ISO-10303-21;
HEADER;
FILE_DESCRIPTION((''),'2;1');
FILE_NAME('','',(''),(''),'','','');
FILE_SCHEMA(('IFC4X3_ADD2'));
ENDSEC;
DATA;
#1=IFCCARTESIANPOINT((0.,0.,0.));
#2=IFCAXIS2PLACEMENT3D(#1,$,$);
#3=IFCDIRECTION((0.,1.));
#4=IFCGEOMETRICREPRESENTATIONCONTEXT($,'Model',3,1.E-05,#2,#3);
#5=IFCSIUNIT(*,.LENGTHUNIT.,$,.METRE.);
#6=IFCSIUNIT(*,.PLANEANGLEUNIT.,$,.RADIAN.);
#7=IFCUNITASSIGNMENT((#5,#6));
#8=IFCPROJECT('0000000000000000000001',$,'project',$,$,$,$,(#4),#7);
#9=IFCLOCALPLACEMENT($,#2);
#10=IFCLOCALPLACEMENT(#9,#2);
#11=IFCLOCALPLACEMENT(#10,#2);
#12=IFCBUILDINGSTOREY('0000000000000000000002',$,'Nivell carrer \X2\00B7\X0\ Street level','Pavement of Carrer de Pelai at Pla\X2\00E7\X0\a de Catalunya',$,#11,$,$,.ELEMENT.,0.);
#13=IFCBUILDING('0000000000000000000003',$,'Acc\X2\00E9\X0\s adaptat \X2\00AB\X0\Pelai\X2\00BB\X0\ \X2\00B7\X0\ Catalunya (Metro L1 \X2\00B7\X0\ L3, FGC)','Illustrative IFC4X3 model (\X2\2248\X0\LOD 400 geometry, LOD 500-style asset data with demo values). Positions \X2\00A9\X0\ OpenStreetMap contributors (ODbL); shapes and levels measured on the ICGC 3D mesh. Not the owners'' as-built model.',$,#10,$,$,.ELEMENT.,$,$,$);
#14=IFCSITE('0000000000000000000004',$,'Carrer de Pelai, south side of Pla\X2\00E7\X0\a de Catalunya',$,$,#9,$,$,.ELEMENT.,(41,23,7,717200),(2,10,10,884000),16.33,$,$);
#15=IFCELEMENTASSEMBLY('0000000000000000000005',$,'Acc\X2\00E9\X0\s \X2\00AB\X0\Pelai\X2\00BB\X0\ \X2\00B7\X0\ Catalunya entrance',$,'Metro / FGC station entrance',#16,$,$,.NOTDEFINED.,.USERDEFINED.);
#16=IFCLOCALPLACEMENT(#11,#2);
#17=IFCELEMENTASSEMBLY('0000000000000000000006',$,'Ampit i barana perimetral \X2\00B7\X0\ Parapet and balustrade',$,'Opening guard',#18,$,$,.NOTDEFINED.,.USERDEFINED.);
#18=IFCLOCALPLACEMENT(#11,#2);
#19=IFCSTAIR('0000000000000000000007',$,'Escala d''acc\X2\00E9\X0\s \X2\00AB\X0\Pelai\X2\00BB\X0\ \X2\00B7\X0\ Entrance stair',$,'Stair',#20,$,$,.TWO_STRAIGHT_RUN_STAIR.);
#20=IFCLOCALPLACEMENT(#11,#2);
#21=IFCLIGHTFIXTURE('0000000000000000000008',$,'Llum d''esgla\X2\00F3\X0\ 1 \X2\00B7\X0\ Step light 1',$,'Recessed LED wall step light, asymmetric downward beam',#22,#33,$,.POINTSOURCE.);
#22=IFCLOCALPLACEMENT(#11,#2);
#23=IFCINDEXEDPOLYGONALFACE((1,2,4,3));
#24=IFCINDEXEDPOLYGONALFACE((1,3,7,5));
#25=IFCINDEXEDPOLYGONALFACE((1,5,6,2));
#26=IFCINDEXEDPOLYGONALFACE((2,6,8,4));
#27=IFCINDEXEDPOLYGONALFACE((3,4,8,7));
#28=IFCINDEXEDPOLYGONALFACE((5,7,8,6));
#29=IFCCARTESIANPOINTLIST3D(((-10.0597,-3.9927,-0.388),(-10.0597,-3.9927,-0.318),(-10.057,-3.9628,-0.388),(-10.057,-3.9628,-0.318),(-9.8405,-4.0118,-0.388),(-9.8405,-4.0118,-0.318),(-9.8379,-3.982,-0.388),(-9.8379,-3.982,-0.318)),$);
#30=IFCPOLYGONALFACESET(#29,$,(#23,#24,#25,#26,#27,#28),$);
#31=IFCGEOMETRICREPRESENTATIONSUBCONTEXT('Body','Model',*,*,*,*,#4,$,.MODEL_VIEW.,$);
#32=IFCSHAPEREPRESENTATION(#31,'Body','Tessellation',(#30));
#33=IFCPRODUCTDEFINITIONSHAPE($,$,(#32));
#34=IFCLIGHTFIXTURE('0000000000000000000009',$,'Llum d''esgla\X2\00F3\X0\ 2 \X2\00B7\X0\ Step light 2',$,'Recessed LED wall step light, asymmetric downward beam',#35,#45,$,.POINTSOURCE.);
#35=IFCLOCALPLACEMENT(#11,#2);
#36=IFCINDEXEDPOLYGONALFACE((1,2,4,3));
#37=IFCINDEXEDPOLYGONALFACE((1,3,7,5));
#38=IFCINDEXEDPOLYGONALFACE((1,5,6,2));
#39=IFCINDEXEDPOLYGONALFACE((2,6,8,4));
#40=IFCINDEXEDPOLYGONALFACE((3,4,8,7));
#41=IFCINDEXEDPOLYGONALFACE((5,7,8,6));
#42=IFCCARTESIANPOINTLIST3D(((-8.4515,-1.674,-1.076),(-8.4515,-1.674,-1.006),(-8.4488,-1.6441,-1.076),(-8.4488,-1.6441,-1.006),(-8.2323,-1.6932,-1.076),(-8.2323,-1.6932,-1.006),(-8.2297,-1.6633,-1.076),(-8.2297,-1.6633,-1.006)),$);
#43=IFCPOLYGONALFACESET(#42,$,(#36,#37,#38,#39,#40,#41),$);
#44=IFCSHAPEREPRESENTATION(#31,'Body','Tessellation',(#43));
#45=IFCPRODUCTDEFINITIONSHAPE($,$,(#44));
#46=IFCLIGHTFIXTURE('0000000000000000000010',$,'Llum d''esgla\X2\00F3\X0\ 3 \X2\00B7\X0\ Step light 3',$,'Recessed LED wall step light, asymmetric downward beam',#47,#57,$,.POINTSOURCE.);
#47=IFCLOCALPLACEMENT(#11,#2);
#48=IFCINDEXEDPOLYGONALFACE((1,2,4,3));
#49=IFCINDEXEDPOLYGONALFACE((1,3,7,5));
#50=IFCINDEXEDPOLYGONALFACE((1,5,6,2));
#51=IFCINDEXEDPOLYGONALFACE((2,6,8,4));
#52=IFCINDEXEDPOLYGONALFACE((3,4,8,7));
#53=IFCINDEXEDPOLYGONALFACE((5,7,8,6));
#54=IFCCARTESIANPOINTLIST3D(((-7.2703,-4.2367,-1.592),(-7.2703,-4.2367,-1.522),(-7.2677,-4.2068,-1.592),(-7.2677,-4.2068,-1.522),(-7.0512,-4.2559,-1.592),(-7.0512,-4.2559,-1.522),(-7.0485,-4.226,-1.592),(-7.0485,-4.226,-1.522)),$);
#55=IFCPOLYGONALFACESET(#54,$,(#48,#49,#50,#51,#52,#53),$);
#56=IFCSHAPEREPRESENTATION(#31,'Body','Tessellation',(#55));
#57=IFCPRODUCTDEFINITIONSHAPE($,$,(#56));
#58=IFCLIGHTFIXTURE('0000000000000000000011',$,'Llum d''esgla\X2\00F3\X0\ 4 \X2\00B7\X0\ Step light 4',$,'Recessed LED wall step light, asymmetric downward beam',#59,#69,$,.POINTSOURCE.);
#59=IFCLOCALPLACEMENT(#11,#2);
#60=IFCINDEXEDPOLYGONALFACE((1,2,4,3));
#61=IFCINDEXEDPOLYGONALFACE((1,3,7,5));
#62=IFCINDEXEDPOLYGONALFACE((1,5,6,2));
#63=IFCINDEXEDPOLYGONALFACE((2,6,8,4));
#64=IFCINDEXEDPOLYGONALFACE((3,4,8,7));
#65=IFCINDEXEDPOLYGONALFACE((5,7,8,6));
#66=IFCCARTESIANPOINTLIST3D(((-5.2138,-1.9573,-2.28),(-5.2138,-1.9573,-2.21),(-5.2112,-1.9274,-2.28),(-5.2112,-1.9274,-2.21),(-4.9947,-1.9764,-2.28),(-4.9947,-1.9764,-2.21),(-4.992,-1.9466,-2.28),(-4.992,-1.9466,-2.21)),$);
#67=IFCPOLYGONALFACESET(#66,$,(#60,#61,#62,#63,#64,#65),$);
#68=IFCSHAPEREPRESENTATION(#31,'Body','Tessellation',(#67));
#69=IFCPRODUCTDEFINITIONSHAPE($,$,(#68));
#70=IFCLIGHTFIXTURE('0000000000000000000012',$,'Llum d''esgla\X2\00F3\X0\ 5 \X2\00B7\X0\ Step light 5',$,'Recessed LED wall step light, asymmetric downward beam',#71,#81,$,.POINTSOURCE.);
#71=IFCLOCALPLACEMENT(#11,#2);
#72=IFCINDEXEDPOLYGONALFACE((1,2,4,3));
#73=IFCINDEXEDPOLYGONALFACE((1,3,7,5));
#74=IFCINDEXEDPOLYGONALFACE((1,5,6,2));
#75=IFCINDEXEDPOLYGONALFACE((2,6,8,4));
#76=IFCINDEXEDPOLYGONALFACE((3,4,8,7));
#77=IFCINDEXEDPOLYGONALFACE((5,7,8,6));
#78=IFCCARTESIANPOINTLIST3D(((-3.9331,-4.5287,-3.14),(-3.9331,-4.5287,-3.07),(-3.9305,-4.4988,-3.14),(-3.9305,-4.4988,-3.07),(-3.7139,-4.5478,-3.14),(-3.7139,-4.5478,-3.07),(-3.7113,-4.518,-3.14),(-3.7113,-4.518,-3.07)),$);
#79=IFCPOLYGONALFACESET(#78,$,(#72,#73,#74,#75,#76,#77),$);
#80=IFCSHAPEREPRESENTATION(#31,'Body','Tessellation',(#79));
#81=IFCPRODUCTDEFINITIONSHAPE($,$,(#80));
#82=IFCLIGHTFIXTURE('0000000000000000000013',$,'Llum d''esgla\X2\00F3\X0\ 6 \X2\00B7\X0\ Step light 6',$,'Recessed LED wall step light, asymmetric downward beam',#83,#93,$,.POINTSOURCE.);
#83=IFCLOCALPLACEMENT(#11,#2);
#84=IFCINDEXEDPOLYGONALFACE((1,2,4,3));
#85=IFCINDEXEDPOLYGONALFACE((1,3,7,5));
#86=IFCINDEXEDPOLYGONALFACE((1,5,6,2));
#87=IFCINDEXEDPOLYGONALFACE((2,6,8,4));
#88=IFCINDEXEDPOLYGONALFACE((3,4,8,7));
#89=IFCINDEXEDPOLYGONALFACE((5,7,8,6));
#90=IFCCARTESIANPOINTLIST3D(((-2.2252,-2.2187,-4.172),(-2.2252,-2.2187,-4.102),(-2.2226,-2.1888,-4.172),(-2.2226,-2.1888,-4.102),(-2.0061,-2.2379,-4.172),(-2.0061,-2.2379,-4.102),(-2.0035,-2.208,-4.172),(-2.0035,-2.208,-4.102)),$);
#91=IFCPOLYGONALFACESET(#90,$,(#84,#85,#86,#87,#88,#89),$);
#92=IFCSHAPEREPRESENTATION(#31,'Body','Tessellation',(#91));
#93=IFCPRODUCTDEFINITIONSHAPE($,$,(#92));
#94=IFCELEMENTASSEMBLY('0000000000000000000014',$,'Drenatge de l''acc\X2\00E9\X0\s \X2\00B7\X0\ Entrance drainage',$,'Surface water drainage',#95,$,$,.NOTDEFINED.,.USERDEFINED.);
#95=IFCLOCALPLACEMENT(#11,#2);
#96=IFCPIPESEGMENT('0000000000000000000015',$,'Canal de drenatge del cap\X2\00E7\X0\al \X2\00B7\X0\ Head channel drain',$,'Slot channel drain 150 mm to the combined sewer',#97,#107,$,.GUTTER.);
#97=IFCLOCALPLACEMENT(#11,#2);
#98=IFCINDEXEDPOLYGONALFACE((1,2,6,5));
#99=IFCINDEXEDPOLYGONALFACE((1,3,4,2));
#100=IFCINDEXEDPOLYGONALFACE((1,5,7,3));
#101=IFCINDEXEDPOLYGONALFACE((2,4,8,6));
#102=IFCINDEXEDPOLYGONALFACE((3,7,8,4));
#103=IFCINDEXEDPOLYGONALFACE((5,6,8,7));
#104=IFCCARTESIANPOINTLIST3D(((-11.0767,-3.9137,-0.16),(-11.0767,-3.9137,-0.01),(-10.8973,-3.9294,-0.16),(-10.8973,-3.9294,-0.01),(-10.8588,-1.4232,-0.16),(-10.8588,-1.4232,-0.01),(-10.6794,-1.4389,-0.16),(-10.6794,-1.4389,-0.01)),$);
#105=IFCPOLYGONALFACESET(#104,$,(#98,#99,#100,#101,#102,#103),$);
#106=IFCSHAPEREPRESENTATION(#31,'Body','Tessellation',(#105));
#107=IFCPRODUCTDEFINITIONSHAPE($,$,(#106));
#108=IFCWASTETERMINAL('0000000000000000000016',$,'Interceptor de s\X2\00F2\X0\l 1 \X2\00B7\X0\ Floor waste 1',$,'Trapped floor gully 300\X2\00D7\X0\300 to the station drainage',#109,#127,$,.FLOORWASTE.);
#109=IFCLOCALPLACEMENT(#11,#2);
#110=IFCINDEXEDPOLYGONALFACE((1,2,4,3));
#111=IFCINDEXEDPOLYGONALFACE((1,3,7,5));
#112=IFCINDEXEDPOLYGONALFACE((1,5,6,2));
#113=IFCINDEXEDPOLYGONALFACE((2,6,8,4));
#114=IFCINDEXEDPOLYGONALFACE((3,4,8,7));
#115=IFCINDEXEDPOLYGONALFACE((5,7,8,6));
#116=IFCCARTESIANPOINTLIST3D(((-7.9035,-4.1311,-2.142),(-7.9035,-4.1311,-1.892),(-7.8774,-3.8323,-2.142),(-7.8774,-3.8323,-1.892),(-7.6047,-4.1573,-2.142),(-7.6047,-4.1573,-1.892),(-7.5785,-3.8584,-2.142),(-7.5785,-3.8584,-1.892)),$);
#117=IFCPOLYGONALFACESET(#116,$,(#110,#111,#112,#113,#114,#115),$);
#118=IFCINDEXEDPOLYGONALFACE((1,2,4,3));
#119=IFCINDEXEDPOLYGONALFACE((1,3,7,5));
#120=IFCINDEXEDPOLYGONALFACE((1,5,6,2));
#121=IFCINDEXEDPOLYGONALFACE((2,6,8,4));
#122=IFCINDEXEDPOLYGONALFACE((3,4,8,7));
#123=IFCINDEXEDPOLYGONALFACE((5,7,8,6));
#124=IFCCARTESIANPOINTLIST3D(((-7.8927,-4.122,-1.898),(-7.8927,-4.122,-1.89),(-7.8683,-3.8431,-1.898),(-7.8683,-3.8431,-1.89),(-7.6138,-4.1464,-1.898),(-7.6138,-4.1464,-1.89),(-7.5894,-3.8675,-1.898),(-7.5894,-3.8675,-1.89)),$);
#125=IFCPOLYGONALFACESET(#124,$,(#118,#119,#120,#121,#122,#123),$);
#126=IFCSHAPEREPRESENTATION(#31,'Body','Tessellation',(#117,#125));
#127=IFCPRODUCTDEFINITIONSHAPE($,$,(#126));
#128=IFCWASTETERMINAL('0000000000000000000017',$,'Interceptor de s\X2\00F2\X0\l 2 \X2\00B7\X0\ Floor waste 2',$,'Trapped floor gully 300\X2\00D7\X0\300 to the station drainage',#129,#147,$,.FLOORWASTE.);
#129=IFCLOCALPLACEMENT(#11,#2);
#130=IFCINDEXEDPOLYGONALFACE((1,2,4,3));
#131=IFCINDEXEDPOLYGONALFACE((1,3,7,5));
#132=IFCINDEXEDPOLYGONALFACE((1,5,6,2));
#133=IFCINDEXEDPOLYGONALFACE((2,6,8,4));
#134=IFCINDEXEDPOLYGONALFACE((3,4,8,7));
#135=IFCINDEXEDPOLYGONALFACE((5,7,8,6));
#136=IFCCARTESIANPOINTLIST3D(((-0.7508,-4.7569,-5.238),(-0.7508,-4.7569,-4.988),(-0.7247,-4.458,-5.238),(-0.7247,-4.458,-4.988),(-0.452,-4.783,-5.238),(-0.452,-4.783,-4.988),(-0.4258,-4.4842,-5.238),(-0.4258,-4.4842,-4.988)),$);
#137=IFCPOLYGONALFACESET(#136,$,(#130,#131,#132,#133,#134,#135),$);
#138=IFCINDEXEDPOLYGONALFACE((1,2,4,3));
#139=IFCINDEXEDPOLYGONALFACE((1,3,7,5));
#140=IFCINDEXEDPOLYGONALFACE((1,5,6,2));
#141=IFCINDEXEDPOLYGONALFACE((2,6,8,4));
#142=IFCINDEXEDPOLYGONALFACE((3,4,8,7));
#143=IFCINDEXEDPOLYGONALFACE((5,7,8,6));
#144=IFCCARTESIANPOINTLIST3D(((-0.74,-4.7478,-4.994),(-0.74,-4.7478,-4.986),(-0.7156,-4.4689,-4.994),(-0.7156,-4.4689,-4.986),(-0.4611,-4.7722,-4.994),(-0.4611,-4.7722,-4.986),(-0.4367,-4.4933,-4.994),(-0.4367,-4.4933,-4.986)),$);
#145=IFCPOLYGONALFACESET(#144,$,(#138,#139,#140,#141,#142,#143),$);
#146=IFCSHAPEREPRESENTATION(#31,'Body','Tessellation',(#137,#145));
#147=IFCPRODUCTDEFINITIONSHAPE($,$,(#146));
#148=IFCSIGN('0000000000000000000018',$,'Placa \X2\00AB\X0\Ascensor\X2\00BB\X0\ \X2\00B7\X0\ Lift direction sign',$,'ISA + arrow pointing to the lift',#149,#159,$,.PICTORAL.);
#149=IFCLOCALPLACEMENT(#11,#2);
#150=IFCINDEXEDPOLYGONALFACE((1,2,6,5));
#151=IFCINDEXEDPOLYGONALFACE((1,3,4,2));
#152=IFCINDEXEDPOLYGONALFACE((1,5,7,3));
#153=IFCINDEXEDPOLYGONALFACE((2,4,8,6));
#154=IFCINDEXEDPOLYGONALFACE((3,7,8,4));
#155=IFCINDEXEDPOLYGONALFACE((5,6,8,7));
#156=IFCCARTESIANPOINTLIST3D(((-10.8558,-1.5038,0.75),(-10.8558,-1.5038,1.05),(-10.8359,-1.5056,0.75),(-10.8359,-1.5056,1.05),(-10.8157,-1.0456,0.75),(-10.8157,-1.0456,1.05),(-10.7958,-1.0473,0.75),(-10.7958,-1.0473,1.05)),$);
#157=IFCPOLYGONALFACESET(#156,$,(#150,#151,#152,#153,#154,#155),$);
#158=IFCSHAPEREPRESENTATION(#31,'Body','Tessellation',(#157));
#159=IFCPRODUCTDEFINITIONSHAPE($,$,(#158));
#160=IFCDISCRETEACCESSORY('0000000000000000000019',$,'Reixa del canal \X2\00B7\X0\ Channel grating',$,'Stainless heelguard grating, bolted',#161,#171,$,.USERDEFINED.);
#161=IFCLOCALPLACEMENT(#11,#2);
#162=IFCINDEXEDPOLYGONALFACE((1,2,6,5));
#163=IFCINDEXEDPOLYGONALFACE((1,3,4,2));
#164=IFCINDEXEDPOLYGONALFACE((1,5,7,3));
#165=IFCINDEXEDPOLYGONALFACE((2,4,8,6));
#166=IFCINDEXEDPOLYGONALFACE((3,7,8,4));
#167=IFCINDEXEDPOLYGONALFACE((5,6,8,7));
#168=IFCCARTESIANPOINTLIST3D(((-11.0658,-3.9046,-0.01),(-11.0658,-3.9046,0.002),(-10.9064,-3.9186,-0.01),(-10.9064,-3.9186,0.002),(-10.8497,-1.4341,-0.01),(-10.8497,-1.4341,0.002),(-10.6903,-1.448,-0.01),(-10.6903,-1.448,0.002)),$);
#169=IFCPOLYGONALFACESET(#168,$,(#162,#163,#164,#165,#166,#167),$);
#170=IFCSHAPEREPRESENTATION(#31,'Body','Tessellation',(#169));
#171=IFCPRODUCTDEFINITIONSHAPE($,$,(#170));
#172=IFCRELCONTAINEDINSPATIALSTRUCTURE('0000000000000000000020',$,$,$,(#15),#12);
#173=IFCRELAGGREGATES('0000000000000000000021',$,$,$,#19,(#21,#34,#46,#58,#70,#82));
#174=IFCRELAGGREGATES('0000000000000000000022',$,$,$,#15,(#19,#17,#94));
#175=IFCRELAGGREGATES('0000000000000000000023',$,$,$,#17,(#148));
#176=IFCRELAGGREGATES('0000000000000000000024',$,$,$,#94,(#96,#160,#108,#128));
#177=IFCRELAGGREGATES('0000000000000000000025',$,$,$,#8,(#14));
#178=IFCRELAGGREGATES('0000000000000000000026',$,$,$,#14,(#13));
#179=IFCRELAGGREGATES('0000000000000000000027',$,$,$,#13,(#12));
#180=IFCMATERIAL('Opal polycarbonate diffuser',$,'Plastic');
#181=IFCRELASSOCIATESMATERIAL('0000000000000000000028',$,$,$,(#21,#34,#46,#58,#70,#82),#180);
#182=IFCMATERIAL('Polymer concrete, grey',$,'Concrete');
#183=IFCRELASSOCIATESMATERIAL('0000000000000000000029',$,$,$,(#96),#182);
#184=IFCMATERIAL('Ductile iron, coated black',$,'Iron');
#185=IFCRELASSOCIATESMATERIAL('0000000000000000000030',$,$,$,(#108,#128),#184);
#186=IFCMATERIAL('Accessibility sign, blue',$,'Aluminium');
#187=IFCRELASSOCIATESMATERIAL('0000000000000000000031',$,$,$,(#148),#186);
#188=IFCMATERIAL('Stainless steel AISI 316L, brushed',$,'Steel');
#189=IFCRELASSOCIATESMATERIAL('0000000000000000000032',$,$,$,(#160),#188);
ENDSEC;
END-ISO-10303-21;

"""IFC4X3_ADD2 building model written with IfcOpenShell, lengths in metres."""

from ifc_helpers import new_model, si_unit, direction, frame, frame_2d, origin, place, context, subcontext, project, spatial, rectangle, extrude, material, element, aggregate, save


model = new_model("IFC4X3_ADD2")

# Units and contexts
model_context = context("Model", 3, precision=1e-05, world=origin(), true_north=direction((0.0, 1.0)))
body_context = subcontext(model_context, "Body", "Model", "MODEL_VIEW")
ifc_project = project(units=[si_unit("LENGTHUNIT", "METRE"), si_unit("PLANEANGLEUNIT", "RADIAN")], contexts=[model_context])

# Site, building, storey
site_placement = place(None, origin())
site = spatial("IfcSite", under=ifc_project, at=site_placement, Name="Carrer de Pelai, south side of Plaça de Catalunya", CompositionType="ELEMENT", RefLatitude=(41, 23, 7, 717200), RefLongitude=(2, 10, 10, 884000), RefElevation=16.33)
building_placement = place(site_placement, origin())
building = spatial("IfcBuilding", under=site, at=building_placement, Name="Accés adaptat «Pelai» · Catalunya (Metro L1 · L3, FGC)", Description="Illustrative IFC4X3 model (≈LOD 400 geometry, LOD 500-style asset data with demo values). Positions © OpenStreetMap contributors (ODbL); shapes and levels measured on the ICGC 3D mesh. Not the owners' as-built model.", CompositionType="ELEMENT")
storey_placement = place(building_placement, origin())
storey = spatial("IfcBuildingStorey", under=building, at=storey_placement, Name="Nivell carrer · Street level", Description="Pavement of Carrer de Pelai at Plaça de Catalunya", CompositionType="ELEMENT", Elevation=0.0)

# Element assemblies
assembly_1_placement = place(building_placement, origin())
assembly_1 = element("IfcElementAssembly", 1, at=assembly_1_placement, inside=storey, Name="Accés «Pelai» · Catalunya entrance", ObjectType="Metro / FGC station entrance", AssemblyPlace="NOTDEFINED", PredefinedType="USERDEFINED")
assembly_2_placement = place(building_placement, origin())
assembly_2 = element("IfcElementAssembly", 2, at=assembly_2_placement, Name="Ampit i barana perimetral · Parapet and balustrade", ObjectType="Opening guard", AssemblyPlace="NOTDEFINED", PredefinedType="USERDEFINED")

# Stair
stair_placement = place(building_placement, origin())
stair = element("IfcStair", 3, at=stair_placement, Name="Escala d'accés «Pelai» · Entrance stair", ObjectType="Stair", PredefinedType="TWO_STRAIGHT_RUN_STAIR")

# Shared definitions
ifc_material_1 = material(Name="Stainless steel AISI 316L, brushed", Category="Steel")

# Light fixtures
ifc_material_2 = material(Name="Opal polycarbonate diffuser", Category="Plastic")
light_fixture_1_placement = place(building_placement, origin())
light_fixture_1 = element("IfcLightFixture", 4, at=light_fixture_1_placement, material=ifc_material_2, Name="Llum d'esglaó 1 · Step light 1", ObjectType="Recessed LED wall step light, asymmetric downward beam", PredefinedType="POINTSOURCE", context=body_context, shape_type="SweptSolid", body=[
    extrude(rectangle(XDim=0.22, YDim=0.03, at=frame_2d((0.0, 0.0), x_axis=(0.996195, -0.087156))), frame((-9.9488, -3.9873, -0.388)), (0.0, 0.0, 1.0), 0.07),
])
light_fixture_2_placement = place(building_placement, origin())
light_fixture_2 = element("IfcLightFixture", 5, at=light_fixture_2_placement, material=ifc_material_2, Name="Llum d'esglaó 2 · Step light 2", ObjectType="Recessed LED wall step light, asymmetric downward beam", PredefinedType="POINTSOURCE", context=body_context, shape_type="SweptSolid", body=[
    extrude(rectangle(XDim=0.22, YDim=0.03, at=frame_2d((0.0, 0.0), x_axis=(0.996195, -0.087156))), frame((-8.3406, -1.6687, -1.076)), (0.0, 0.0, 1.0), 0.07),
])
light_fixture_3_placement = place(building_placement, origin())
light_fixture_3 = element("IfcLightFixture", 6, at=light_fixture_3_placement, material=ifc_material_2, Name="Llum d'esglaó 3 · Step light 3", ObjectType="Recessed LED wall step light, asymmetric downward beam", PredefinedType="POINTSOURCE", context=body_context, shape_type="SweptSolid", body=[
    extrude(rectangle(XDim=0.22, YDim=0.03, at=frame_2d((0.0, 0.0), x_axis=(0.996195, -0.087156))), frame((-7.1594, -4.2313, -1.592)), (0.0, 0.0, 1.0), 0.07),
])
light_fixture_4_placement = place(building_placement, origin())
light_fixture_4 = element("IfcLightFixture", 7, at=light_fixture_4_placement, material=ifc_material_2, Name="Llum d'esglaó 4 · Step light 4", ObjectType="Recessed LED wall step light, asymmetric downward beam", PredefinedType="POINTSOURCE", context=body_context, shape_type="SweptSolid", body=[
    extrude(rectangle(XDim=0.22, YDim=0.03, at=frame_2d((0.0, 0.0), x_axis=(0.996195, -0.087156))), frame((-5.1029, -1.9519, -2.28)), (0.0, 0.0, 1.0), 0.07),
])
light_fixture_5_placement = place(building_placement, origin())
light_fixture_5 = element("IfcLightFixture", 8, at=light_fixture_5_placement, material=ifc_material_2, Name="Llum d'esglaó 5 · Step light 5", ObjectType="Recessed LED wall step light, asymmetric downward beam", PredefinedType="POINTSOURCE", context=body_context, shape_type="SweptSolid", body=[
    extrude(rectangle(XDim=0.22, YDim=0.03, at=frame_2d((0.0, 0.0), x_axis=(0.996195, -0.087156))), frame((-3.8222, -4.5233, -3.14)), (0.0, 0.0, 1.0), 0.07),
])
light_fixture_6_placement = place(building_placement, origin())
light_fixture_6 = element("IfcLightFixture", 9, at=light_fixture_6_placement, material=ifc_material_2, Name="Llum d'esglaó 6 · Step light 6", ObjectType="Recessed LED wall step light, asymmetric downward beam", PredefinedType="POINTSOURCE", context=body_context, shape_type="SweptSolid", body=[
    extrude(rectangle(XDim=0.22, YDim=0.03, at=frame_2d((0.0, 0.0), x_axis=(0.996195, -0.087156))), frame((-2.1144, -2.2134, -4.172)), (0.0, 0.0, 1.0), 0.07),
])
aggregate(stair, [light_fixture_1, light_fixture_2, light_fixture_3, light_fixture_4, light_fixture_5, light_fixture_6])

# Element assembly
assembly_3_placement = place(building_placement, origin())
assembly_3 = element("IfcElementAssembly", 10, at=assembly_3_placement, Name="Drenatge de l'accés · Entrance drainage", ObjectType="Surface water drainage", AssemblyPlace="NOTDEFINED", PredefinedType="USERDEFINED")
aggregate(assembly_1, [stair, assembly_2, assembly_3])

# Pipe segment
ifc_material_3 = material(Name="Polymer concrete, grey", Category="Concrete")
pipe_segment_placement = place(building_placement, origin())
pipe_segment = element("IfcPipeSegment", 11, at=pipe_segment_placement, material=ifc_material_3, Name="Canal de drenatge del capçal · Head channel drain", ObjectType="Slot channel drain 150 mm to the combined sewer", PredefinedType="GUTTER", context=body_context, shape_type="SweptSolid", body=[
    extrude(rectangle(XDim=0.18, YDim=2.5, at=frame_2d((0.0, 0.0), x_axis=(0.996195, -0.087156))), frame((-10.8781, -2.6763, -0.16)), (0.0, 0.0, 1.0), 0.15),
])

# Waste terminals
ifc_material_4 = material(Name="Ductile iron, coated black", Category="Iron")
waste_terminal_1_placement = place(building_placement, origin())
waste_terminal_1 = element("IfcWasteTerminal", 12, at=waste_terminal_1_placement, material=ifc_material_4, Name="Interceptor de sòl 1 · Floor waste 1", ObjectType="Trapped floor gully 300×300 to the station drainage", PredefinedType="FLOORWASTE", context=body_context, shape_type="SweptSolid", body=[
    extrude(rectangle(XDim=0.3, YDim=0.3, at=frame_2d((0.0, 0.0), x_axis=(0.996195, -0.087156))), frame((-7.741, -3.9948, -2.142)), (0.0, 0.0, 1.0), 0.25),
    extrude(rectangle(XDim=0.28, YDim=0.28, at=frame_2d((0.0, 0.0), x_axis=(0.996195, -0.087156))), frame((-7.741, -3.9948, -1.898)), (0.0, 0.0, 1.0), 0.008),
])
waste_terminal_2_placement = place(building_placement, origin())
waste_terminal_2 = element("IfcWasteTerminal", 13, at=waste_terminal_2_placement, material=ifc_material_4, Name="Interceptor de sòl 2 · Floor waste 2", ObjectType="Trapped floor gully 300×300 to the station drainage", PredefinedType="FLOORWASTE", context=body_context, shape_type="SweptSolid", body=[
    extrude(rectangle(XDim=0.3, YDim=0.3, at=frame_2d((0.0, 0.0), x_axis=(0.996195, -0.087156))), frame((-0.5883, -4.6205, -5.238)), (0.0, 0.0, 1.0), 0.25),
    extrude(rectangle(XDim=0.28, YDim=0.28, at=frame_2d((0.0, 0.0), x_axis=(0.996195, -0.087156))), frame((-0.5883, -4.6205, -4.994)), (0.0, 0.0, 1.0), 0.008),
])

# Sign
ifc_material_5 = material(Name="Accessibility sign, blue", Category="Aluminium")
sign_placement = place(building_placement, origin())
sign = element("IfcSign", 14, at=sign_placement, material=ifc_material_5, Name="Placa «Ascensor» · Lift direction sign", ObjectType="ISA + arrow pointing to the lift", PredefinedType="PICTORAL", context=body_context, shape_type="SweptSolid", body=[
    extrude(rectangle(XDim=0.02, YDim=0.46, at=frame_2d((0.0, 0.0), x_axis=(0.996195, -0.087156))), frame((-10.8258, -1.2756, 0.75)), (0.0, 0.0, 1.0), 0.3),
])
aggregate(assembly_2, [sign])

# Discrete accessory
discrete_accessory_placement = place(building_placement, origin())
discrete_accessory = element("IfcDiscreteAccessory", 15, at=discrete_accessory_placement, material=ifc_material_1, Name="Reixa del canal · Channel grating", ObjectType="Stainless heelguard grating, bolted", PredefinedType="USERDEFINED", context=body_context, shape_type="SweptSolid", body=[
    extrude(rectangle(XDim=0.16, YDim=2.48, at=frame_2d((0.0, 0.0), x_axis=(0.996195, -0.087156))), frame((-10.8781, -2.6763, -0.01)), (0.0, 0.0, 1.0), 0.012),
])
aggregate(assembly_3, [pipe_segment, discrete_accessory, waste_terminal_1, waste_terminal_2])

save(model, "model.ifc")
